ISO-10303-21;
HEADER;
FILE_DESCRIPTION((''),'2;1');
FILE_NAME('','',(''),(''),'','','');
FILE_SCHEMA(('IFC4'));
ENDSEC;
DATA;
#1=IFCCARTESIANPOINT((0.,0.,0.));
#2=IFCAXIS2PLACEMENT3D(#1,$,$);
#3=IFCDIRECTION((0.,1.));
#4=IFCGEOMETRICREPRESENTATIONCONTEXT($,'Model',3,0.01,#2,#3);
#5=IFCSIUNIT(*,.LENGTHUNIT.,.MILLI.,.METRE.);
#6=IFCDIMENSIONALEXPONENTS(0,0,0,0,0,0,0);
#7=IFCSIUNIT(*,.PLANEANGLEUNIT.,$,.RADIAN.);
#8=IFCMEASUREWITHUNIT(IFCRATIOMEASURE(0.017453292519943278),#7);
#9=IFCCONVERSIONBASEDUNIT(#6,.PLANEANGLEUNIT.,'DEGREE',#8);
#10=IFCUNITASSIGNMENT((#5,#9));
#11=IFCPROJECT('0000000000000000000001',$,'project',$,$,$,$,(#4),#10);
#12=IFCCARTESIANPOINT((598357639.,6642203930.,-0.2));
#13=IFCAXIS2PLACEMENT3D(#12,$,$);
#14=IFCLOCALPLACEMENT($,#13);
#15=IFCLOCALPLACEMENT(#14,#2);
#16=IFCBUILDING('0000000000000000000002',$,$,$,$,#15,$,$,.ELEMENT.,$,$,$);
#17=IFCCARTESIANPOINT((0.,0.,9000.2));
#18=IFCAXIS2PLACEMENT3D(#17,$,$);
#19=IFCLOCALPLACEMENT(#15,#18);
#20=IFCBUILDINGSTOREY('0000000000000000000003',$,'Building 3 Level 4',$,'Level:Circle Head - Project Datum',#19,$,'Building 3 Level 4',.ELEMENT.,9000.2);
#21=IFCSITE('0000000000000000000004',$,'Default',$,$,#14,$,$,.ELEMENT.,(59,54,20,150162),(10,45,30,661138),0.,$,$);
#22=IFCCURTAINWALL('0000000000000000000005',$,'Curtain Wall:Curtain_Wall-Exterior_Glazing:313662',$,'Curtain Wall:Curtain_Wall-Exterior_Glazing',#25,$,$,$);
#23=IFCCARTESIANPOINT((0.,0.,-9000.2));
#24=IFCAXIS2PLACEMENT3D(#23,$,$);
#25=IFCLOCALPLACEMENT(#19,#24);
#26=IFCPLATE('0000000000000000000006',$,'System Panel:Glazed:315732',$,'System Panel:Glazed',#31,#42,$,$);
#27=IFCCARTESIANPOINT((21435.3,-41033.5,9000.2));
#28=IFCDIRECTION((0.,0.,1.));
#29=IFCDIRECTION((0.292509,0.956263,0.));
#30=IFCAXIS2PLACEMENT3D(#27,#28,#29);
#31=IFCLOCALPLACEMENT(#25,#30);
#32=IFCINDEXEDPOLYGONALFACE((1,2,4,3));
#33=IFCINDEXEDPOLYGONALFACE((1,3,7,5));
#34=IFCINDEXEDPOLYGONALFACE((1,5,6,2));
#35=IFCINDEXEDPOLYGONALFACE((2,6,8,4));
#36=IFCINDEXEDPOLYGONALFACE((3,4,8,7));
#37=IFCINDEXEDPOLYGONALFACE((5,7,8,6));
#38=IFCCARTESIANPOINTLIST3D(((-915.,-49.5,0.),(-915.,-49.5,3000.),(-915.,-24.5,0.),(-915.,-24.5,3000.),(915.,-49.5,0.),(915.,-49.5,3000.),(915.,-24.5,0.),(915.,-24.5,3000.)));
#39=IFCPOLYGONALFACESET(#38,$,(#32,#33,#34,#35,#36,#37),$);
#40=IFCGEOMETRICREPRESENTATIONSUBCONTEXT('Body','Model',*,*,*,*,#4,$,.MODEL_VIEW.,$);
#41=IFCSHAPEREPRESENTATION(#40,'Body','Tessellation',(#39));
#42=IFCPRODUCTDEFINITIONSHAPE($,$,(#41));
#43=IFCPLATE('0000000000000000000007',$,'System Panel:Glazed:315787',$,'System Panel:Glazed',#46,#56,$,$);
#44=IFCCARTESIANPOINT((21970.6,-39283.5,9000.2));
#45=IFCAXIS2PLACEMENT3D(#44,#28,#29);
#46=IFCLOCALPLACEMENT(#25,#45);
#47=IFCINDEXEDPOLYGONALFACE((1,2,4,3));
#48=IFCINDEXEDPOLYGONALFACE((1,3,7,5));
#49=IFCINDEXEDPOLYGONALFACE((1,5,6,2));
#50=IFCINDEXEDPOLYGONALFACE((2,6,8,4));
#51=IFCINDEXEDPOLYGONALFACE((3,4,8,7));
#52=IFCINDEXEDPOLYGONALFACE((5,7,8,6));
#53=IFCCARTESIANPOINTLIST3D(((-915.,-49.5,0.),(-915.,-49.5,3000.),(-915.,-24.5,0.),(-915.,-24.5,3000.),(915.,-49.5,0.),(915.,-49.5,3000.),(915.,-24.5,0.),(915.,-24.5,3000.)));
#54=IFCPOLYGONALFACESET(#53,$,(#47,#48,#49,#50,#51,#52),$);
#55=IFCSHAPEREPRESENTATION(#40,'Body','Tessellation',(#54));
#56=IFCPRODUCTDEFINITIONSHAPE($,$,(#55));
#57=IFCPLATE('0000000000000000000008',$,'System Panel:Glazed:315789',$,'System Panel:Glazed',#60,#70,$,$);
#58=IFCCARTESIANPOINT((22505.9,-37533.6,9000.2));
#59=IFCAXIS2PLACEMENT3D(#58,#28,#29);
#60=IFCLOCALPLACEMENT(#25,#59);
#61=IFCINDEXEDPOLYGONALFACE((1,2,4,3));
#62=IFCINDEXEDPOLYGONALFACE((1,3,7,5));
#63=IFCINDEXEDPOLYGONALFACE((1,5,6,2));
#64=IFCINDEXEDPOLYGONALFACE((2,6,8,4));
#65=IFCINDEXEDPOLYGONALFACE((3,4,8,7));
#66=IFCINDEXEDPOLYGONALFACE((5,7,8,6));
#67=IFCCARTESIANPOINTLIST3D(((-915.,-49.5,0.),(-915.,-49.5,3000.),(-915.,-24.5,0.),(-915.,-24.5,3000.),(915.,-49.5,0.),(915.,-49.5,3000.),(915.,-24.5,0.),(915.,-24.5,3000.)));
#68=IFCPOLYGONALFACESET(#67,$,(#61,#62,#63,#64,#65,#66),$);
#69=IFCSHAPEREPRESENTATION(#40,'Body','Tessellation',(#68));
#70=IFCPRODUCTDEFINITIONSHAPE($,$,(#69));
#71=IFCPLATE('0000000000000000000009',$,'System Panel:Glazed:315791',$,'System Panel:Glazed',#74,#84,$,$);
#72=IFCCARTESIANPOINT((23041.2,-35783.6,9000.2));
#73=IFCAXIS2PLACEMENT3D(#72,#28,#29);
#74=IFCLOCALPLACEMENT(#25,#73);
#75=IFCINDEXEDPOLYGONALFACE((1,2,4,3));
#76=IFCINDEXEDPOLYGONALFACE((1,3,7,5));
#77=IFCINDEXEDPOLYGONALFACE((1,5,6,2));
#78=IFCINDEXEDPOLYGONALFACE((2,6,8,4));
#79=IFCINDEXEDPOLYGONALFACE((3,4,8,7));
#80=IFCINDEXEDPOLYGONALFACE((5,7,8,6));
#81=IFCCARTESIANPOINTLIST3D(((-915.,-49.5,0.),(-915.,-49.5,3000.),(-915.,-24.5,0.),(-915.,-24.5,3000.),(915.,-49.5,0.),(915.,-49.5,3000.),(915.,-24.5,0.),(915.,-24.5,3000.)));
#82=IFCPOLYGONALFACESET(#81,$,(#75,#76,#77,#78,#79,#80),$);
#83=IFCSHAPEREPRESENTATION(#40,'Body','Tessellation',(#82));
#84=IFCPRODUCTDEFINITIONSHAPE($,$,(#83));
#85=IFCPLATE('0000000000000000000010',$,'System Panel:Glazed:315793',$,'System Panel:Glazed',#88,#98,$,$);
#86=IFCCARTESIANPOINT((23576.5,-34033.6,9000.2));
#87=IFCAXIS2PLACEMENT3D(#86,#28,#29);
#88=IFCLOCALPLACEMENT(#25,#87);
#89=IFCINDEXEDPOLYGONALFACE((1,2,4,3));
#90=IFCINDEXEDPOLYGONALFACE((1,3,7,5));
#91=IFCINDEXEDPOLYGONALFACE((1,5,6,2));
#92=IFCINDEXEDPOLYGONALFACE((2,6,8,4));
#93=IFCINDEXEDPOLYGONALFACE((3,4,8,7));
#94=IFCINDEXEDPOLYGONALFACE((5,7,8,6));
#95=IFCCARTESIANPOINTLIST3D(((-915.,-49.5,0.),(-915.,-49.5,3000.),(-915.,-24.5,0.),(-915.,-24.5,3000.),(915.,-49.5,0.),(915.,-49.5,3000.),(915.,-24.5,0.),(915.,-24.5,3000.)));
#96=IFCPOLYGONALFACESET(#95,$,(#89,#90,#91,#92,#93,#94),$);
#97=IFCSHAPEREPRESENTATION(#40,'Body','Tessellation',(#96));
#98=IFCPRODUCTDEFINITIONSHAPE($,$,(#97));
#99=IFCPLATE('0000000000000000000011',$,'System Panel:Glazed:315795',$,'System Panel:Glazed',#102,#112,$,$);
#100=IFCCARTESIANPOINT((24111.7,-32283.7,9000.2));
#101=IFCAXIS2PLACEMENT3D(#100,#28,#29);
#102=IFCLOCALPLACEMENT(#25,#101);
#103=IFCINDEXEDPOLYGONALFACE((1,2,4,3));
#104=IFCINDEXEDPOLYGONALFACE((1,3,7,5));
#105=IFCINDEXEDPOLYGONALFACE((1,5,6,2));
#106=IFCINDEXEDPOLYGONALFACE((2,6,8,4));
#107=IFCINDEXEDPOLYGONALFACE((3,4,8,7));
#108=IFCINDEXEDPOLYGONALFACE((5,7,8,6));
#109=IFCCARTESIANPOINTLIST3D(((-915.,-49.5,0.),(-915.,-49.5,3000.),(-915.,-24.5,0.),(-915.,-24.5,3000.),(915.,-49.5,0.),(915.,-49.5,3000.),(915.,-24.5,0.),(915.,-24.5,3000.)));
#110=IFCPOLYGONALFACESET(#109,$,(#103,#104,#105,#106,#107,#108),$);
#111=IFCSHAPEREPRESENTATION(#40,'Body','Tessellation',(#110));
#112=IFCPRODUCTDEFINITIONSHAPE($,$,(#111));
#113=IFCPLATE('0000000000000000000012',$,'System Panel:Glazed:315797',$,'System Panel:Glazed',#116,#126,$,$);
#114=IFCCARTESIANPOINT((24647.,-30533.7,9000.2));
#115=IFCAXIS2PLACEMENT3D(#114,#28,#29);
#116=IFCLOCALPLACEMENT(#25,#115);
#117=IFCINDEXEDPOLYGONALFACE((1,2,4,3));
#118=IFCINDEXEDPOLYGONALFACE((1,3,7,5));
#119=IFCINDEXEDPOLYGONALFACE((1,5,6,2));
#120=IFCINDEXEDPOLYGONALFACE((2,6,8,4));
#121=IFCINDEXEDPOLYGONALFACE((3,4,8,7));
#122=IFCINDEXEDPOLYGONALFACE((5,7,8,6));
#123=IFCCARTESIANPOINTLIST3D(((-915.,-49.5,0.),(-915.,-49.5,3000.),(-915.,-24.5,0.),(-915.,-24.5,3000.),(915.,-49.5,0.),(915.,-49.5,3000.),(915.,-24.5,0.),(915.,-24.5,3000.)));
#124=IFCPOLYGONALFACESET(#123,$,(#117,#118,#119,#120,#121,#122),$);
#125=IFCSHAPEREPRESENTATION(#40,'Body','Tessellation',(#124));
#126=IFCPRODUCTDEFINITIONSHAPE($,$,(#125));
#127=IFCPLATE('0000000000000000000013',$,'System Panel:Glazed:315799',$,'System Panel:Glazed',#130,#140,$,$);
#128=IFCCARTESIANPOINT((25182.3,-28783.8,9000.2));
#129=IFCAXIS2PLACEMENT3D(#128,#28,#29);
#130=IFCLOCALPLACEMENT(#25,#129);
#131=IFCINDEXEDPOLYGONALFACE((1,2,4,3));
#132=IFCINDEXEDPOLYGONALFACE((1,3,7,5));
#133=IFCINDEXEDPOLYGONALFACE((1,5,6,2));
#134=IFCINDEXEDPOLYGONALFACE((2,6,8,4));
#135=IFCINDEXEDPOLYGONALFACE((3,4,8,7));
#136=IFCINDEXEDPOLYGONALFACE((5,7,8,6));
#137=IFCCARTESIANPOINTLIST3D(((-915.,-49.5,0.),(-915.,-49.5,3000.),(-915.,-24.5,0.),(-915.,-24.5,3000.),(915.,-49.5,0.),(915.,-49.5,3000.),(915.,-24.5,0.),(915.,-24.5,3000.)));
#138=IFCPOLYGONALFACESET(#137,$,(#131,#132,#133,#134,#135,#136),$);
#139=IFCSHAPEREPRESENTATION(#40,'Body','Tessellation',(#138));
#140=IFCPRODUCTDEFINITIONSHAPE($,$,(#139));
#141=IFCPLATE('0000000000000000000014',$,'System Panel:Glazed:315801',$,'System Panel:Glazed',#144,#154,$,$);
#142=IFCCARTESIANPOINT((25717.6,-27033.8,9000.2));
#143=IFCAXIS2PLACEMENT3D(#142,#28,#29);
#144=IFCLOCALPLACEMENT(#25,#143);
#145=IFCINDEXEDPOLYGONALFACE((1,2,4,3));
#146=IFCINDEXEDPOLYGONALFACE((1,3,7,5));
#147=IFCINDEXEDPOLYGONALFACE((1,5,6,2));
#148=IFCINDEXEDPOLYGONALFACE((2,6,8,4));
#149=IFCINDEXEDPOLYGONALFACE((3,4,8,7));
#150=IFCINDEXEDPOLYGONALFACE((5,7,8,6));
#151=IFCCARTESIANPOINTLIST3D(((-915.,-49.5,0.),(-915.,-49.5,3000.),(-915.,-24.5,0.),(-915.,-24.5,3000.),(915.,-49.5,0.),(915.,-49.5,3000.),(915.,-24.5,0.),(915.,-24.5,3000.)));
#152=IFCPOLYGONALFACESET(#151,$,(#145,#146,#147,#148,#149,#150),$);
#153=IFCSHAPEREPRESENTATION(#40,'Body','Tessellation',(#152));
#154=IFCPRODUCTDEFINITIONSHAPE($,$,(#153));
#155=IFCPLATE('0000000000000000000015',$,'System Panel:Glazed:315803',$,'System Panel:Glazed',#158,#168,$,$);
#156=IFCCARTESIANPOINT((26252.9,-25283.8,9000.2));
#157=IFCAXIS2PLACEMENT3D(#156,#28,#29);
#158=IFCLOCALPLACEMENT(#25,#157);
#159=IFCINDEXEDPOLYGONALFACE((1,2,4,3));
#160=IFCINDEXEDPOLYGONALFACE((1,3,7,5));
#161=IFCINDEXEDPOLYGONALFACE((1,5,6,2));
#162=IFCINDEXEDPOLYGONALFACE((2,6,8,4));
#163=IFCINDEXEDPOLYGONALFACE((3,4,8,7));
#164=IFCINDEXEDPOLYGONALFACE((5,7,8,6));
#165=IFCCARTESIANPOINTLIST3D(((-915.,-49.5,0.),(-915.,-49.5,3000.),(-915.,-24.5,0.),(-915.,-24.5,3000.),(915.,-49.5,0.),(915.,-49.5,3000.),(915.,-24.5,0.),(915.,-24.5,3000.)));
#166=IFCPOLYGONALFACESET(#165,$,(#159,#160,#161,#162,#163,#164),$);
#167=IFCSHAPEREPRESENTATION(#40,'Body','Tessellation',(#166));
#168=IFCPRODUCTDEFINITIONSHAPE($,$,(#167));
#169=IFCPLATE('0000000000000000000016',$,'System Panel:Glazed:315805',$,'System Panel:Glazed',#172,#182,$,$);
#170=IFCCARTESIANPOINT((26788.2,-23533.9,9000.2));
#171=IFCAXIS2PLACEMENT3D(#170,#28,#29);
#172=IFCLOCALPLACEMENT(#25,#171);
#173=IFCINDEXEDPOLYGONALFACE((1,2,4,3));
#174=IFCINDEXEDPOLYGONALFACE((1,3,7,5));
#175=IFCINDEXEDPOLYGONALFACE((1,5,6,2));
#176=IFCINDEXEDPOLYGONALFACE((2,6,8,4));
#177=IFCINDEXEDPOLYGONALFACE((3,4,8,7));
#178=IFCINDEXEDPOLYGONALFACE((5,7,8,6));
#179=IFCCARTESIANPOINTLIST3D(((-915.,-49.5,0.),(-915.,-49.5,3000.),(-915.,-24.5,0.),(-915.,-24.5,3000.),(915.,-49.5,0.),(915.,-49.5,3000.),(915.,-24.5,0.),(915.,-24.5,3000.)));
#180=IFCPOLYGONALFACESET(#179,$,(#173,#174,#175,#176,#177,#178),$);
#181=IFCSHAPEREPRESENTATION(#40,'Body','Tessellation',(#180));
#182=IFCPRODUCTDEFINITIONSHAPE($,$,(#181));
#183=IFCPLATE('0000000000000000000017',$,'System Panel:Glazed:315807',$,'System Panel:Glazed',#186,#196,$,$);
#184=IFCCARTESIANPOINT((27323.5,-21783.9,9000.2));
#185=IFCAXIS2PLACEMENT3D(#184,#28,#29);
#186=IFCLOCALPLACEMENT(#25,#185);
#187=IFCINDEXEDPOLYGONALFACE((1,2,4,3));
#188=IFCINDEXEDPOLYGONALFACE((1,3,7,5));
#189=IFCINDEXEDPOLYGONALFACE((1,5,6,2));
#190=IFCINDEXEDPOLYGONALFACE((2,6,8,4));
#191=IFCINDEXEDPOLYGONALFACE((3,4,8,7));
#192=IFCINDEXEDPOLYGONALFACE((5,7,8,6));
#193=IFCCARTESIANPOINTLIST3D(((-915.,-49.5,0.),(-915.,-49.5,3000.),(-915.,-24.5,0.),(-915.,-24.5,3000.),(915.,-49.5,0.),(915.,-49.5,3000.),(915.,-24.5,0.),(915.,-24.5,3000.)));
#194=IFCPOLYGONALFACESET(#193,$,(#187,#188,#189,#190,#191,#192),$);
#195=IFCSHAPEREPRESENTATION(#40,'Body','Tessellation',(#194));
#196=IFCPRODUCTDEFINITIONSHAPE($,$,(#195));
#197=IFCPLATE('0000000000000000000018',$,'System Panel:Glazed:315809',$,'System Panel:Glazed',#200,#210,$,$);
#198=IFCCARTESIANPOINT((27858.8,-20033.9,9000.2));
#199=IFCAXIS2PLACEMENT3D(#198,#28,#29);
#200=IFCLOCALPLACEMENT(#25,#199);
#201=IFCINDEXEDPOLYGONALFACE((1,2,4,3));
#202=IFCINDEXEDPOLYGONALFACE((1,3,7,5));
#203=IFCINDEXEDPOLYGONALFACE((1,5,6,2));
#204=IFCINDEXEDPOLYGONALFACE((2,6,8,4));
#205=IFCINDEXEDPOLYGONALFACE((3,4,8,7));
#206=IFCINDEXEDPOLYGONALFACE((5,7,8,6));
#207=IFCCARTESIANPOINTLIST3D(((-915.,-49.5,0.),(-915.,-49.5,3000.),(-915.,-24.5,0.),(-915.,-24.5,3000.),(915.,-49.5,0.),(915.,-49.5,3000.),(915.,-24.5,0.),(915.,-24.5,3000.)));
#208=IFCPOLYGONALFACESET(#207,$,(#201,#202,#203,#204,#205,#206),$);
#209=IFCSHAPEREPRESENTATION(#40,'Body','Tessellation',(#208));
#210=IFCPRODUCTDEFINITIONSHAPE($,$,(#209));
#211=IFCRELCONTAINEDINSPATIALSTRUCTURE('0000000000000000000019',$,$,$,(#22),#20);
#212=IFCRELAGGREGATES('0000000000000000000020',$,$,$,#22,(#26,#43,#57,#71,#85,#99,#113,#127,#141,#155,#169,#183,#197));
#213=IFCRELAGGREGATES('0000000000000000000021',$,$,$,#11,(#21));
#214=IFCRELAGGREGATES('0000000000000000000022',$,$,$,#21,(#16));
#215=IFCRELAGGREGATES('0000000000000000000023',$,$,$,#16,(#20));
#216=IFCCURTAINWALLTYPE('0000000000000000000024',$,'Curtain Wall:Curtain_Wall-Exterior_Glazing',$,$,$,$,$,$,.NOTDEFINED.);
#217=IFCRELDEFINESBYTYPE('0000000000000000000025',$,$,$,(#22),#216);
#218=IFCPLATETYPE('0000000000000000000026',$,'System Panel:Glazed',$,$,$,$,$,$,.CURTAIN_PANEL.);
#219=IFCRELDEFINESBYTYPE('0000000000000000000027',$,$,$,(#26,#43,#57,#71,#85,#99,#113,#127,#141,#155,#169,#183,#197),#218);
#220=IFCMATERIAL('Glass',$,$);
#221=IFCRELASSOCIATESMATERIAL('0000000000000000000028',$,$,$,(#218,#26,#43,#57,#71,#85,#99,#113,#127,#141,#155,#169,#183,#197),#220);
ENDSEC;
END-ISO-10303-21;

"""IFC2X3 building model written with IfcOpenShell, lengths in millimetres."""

from ifc_helpers import new_model, entity, si_unit, converted_unit, direction, frame, frame_2d, origin, place, context, subcontext, project, spatial, rectangle, extrude, source, transform, mapped, material, type_object, type_shapes, element, aggregate, save


model = new_model("IFC2X3")

# Units and contexts
model_context = context("Model", 3, precision=0.01, world=origin(), true_north=direction((0.0, 1.0)))
body_context = subcontext(model_context, "Body", "Model", "MODEL_VIEW")
ifc_project = project(units=[si_unit("LENGTHUNIT", "METRE", prefix="MILLI"), converted_unit("PLANEANGLEUNIT", "DEGREE", entity("IfcRatioMeasure", 0.017453292519943278), si_unit("PLANEANGLEUNIT", "RADIAN"), dimensions=[0, 0, 0, 0, 0, 0, 0])], contexts=[model_context])

# Site, building, storey
site_placement = place(None, frame((598357639.0, 6642203930.0, -0.2)))
site = spatial("IfcSite", under=ifc_project, at=site_placement, Name="Default", CompositionType="ELEMENT", RefLatitude=(59, 54, 20, 150162), RefLongitude=(10, 45, 30, 661138), RefElevation=0.0)
building_placement = place(site_placement, origin())
building = spatial("IfcBuilding", under=site, at=building_placement, CompositionType="ELEMENT")
storey_placement = place(building_placement, frame((0.0, 0.0, 9000.2)))
storey = spatial("IfcBuildingStorey", under=building, at=storey_placement, Name="Building 3 Level 4", ObjectType="Level:Circle Head - Project Datum", LongName="Building 3 Level 4", CompositionType="ELEMENT", Elevation=9000.2)

# Curtain wall, plates
curtain_wall_type = type_object("IfcCurtainWallType", Name="Curtain Wall:Curtain_Wall-Exterior_Glazing", PredefinedType="NOTDEFINED")
curtain_wall_1_placement = place(storey_placement, frame((0.0, 0.0, -9000.2)))
curtain_wall_1 = element("IfcCurtainWall", 1, at=curtain_wall_1_placement, inside=storey, type_object=curtain_wall_type, Name="Curtain Wall:Curtain_Wall-Exterior_Glazing:313662", ObjectType="Curtain Wall:Curtain_Wall-Exterior_Glazing")
ifc_material_1 = material(Name="Glass")
plate_type_1 = type_object("IfcPlateType", Name="System Panel:Glazed", PredefinedType="CURTAIN_PANEL", material=ifc_material_1)
shared_shape_1 = source(origin(), body_context, "Body", "SweptSolid", [
    extrude(rectangle(XDim=25.0, YDim=1830.0, at=frame_2d((0.0, 0.0), x_axis=(1.0, 0.0))), frame((0.0, -37.0, 0.0), z_axis=(0.0, 0.0, 1.0), x_axis=(0.0, 1.0, 0.0)), (0.0, 0.0, 1.0), 3000.0),
])
type_shapes(plate_type_1, [shared_shape_1])
plate_1_placement = place(curtain_wall_1_placement, frame((21435.3, -41033.5, 9000.2), z_axis=(0.0, 0.0, 1.0), x_axis=(0.292509, 0.956263, 0.0)))
plate_1 = element("IfcPlate", 2, at=plate_1_placement, type_object=plate_type_1, material=ifc_material_1, Name="System Panel:Glazed:315732", ObjectType="System Panel:Glazed", context=body_context, shape_type="MappedRepresentation", body=[
    mapped(shared_shape_1, transform((0.0, 0.0, 0.0), scale=1.0)),
])
plate_2_placement = place(curtain_wall_1_placement, frame((21970.6, -39283.5, 9000.2), z_axis=(0.0, 0.0, 1.0), x_axis=(0.292509, 0.956263, 0.0)))
plate_2 = element("IfcPlate", 3, at=plate_2_placement, type_object=plate_type_1, material=ifc_material_1, Name="System Panel:Glazed:315787", ObjectType="System Panel:Glazed", context=body_context, shape_type="MappedRepresentation", body=[
    mapped(shared_shape_1, transform((0.0, 0.0, 0.0), scale=1.0)),
])
plate_3_placement = place(curtain_wall_1_placement, frame((22505.9, -37533.6, 9000.2), z_axis=(0.0, 0.0, 1.0), x_axis=(0.292509, 0.956263, 0.0)))
plate_3 = element("IfcPlate", 4, at=plate_3_placement, type_object=plate_type_1, material=ifc_material_1, Name="System Panel:Glazed:315789", ObjectType="System Panel:Glazed", context=body_context, shape_type="MappedRepresentation", body=[
    mapped(shared_shape_1, transform((0.0, 0.0, 0.0), scale=1.0)),
])
plate_4_placement = place(curtain_wall_1_placement, frame((23041.2, -35783.6, 9000.2), z_axis=(0.0, 0.0, 1.0), x_axis=(0.292509, 0.956263, 0.0)))
plate_4 = element("IfcPlate", 5, at=plate_4_placement, type_object=plate_type_1, material=ifc_material_1, Name="System Panel:Glazed:315791", ObjectType="System Panel:Glazed", context=body_context, shape_type="MappedRepresentation", body=[
    mapped(shared_shape_1, transform((0.0, 0.0, 0.0), scale=1.0)),
])
plate_5_placement = place(curtain_wall_1_placement, frame((23576.5, -34033.6, 9000.2), z_axis=(0.0, 0.0, 1.0), x_axis=(0.292509, 0.956263, 0.0)))
plate_5 = element("IfcPlate", 6, at=plate_5_placement, type_object=plate_type_1, material=ifc_material_1, Name="System Panel:Glazed:315793", ObjectType="System Panel:Glazed", context=body_context, shape_type="MappedRepresentation", body=[
    mapped(shared_shape_1, transform((0.0, 0.0, 0.0), scale=1.0)),
])
plate_6_placement = place(curtain_wall_1_placement, frame((24111.7, -32283.7, 9000.2), z_axis=(0.0, 0.0, 1.0), x_axis=(0.292509, 0.956263, 0.0)))
plate_6 = element("IfcPlate", 7, at=plate_6_placement, type_object=plate_type_1, material=ifc_material_1, Name="System Panel:Glazed:315795", ObjectType="System Panel:Glazed", context=body_context, shape_type="MappedRepresentation", body=[
    mapped(shared_shape_1, transform((0.0, 0.0, 0.0), scale=1.0)),
])
plate_7_placement = place(curtain_wall_1_placement, frame((24647.0, -30533.7, 9000.2), z_axis=(0.0, 0.0, 1.0), x_axis=(0.292509, 0.956263, 0.0)))
plate_7 = element("IfcPlate", 8, at=plate_7_placement, type_object=plate_type_1, material=ifc_material_1, Name="System Panel:Glazed:315797", ObjectType="System Panel:Glazed", context=body_context, shape_type="MappedRepresentation", body=[
    mapped(shared_shape_1, transform((0.0, 0.0, 0.0), scale=1.0)),
])
plate_8_placement = place(curtain_wall_1_placement, frame((25182.3, -28783.8, 9000.2), z_axis=(0.0, 0.0, 1.0), x_axis=(0.292509, 0.956263, 0.0)))
plate_8 = element("IfcPlate", 9, at=plate_8_placement, type_object=plate_type_1, material=ifc_material_1, Name="System Panel:Glazed:315799", ObjectType="System Panel:Glazed", context=body_context, shape_type="MappedRepresentation", body=[
    mapped(shared_shape_1, transform((0.0, 0.0, 0.0), scale=1.0)),
])
plate_9_placement = place(curtain_wall_1_placement, frame((25717.6, -27033.8, 9000.2), z_axis=(0.0, 0.0, 1.0), x_axis=(0.292509, 0.956263, 0.0)))
plate_9 = element("IfcPlate", 10, at=plate_9_placement, type_object=plate_type_1, material=ifc_material_1, Name="System Panel:Glazed:315801", ObjectType="System Panel:Glazed", context=body_context, shape_type="MappedRepresentation", body=[
    mapped(shared_shape_1, transform((0.0, 0.0, 0.0), scale=1.0)),
])
plate_10_placement = place(curtain_wall_1_placement, frame((26252.9, -25283.8, 9000.2), z_axis=(0.0, 0.0, 1.0), x_axis=(0.292509, 0.956263, 0.0)))
plate_10 = element("IfcPlate", 11, at=plate_10_placement, type_object=plate_type_1, material=ifc_material_1, Name="System Panel:Glazed:315803", ObjectType="System Panel:Glazed", context=body_context, shape_type="MappedRepresentation", body=[
    mapped(shared_shape_1, transform((0.0, 0.0, 0.0), scale=1.0)),
])
plate_11_placement = place(curtain_wall_1_placement, frame((26788.2, -23533.9, 9000.2), z_axis=(0.0, 0.0, 1.0), x_axis=(0.292509, 0.956263, 0.0)))
plate_11 = element("IfcPlate", 12, at=plate_11_placement, type_object=plate_type_1, material=ifc_material_1, Name="System Panel:Glazed:315805", ObjectType="System Panel:Glazed", context=body_context, shape_type="MappedRepresentation", body=[
    mapped(shared_shape_1, transform((0.0, 0.0, 0.0), scale=1.0)),
])
plate_12_placement = place(curtain_wall_1_placement, frame((27323.5, -21783.9, 9000.2), z_axis=(0.0, 0.0, 1.0), x_axis=(0.292509, 0.956263, 0.0)))
plate_12 = element("IfcPlate", 13, at=plate_12_placement, type_object=plate_type_1, material=ifc_material_1, Name="System Panel:Glazed:315807", ObjectType="System Panel:Glazed", context=body_context, shape_type="MappedRepresentation", body=[
    mapped(shared_shape_1, transform((0.0, 0.0, 0.0), scale=1.0)),
])
plate_13_placement = place(curtain_wall_1_placement, frame((27858.8, -20033.9, 9000.2), z_axis=(0.0, 0.0, 1.0), x_axis=(0.292509, 0.956263, 0.0)))
plate_13 = element("IfcPlate", 14, at=plate_13_placement, type_object=plate_type_1, material=ifc_material_1, Name="System Panel:Glazed:315809", ObjectType="System Panel:Glazed", context=body_context, shape_type="MappedRepresentation", body=[
    mapped(shared_shape_1, transform((0.0, 0.0, 0.0), scale=1.0)),
])

aggregate(curtain_wall_1, [plate_1, plate_2, plate_3, plate_4, plate_5, plate_6, plate_7, plate_8, plate_9, plate_10, plate_11, plate_12, plate_13])

save(model, "model.ifc")
